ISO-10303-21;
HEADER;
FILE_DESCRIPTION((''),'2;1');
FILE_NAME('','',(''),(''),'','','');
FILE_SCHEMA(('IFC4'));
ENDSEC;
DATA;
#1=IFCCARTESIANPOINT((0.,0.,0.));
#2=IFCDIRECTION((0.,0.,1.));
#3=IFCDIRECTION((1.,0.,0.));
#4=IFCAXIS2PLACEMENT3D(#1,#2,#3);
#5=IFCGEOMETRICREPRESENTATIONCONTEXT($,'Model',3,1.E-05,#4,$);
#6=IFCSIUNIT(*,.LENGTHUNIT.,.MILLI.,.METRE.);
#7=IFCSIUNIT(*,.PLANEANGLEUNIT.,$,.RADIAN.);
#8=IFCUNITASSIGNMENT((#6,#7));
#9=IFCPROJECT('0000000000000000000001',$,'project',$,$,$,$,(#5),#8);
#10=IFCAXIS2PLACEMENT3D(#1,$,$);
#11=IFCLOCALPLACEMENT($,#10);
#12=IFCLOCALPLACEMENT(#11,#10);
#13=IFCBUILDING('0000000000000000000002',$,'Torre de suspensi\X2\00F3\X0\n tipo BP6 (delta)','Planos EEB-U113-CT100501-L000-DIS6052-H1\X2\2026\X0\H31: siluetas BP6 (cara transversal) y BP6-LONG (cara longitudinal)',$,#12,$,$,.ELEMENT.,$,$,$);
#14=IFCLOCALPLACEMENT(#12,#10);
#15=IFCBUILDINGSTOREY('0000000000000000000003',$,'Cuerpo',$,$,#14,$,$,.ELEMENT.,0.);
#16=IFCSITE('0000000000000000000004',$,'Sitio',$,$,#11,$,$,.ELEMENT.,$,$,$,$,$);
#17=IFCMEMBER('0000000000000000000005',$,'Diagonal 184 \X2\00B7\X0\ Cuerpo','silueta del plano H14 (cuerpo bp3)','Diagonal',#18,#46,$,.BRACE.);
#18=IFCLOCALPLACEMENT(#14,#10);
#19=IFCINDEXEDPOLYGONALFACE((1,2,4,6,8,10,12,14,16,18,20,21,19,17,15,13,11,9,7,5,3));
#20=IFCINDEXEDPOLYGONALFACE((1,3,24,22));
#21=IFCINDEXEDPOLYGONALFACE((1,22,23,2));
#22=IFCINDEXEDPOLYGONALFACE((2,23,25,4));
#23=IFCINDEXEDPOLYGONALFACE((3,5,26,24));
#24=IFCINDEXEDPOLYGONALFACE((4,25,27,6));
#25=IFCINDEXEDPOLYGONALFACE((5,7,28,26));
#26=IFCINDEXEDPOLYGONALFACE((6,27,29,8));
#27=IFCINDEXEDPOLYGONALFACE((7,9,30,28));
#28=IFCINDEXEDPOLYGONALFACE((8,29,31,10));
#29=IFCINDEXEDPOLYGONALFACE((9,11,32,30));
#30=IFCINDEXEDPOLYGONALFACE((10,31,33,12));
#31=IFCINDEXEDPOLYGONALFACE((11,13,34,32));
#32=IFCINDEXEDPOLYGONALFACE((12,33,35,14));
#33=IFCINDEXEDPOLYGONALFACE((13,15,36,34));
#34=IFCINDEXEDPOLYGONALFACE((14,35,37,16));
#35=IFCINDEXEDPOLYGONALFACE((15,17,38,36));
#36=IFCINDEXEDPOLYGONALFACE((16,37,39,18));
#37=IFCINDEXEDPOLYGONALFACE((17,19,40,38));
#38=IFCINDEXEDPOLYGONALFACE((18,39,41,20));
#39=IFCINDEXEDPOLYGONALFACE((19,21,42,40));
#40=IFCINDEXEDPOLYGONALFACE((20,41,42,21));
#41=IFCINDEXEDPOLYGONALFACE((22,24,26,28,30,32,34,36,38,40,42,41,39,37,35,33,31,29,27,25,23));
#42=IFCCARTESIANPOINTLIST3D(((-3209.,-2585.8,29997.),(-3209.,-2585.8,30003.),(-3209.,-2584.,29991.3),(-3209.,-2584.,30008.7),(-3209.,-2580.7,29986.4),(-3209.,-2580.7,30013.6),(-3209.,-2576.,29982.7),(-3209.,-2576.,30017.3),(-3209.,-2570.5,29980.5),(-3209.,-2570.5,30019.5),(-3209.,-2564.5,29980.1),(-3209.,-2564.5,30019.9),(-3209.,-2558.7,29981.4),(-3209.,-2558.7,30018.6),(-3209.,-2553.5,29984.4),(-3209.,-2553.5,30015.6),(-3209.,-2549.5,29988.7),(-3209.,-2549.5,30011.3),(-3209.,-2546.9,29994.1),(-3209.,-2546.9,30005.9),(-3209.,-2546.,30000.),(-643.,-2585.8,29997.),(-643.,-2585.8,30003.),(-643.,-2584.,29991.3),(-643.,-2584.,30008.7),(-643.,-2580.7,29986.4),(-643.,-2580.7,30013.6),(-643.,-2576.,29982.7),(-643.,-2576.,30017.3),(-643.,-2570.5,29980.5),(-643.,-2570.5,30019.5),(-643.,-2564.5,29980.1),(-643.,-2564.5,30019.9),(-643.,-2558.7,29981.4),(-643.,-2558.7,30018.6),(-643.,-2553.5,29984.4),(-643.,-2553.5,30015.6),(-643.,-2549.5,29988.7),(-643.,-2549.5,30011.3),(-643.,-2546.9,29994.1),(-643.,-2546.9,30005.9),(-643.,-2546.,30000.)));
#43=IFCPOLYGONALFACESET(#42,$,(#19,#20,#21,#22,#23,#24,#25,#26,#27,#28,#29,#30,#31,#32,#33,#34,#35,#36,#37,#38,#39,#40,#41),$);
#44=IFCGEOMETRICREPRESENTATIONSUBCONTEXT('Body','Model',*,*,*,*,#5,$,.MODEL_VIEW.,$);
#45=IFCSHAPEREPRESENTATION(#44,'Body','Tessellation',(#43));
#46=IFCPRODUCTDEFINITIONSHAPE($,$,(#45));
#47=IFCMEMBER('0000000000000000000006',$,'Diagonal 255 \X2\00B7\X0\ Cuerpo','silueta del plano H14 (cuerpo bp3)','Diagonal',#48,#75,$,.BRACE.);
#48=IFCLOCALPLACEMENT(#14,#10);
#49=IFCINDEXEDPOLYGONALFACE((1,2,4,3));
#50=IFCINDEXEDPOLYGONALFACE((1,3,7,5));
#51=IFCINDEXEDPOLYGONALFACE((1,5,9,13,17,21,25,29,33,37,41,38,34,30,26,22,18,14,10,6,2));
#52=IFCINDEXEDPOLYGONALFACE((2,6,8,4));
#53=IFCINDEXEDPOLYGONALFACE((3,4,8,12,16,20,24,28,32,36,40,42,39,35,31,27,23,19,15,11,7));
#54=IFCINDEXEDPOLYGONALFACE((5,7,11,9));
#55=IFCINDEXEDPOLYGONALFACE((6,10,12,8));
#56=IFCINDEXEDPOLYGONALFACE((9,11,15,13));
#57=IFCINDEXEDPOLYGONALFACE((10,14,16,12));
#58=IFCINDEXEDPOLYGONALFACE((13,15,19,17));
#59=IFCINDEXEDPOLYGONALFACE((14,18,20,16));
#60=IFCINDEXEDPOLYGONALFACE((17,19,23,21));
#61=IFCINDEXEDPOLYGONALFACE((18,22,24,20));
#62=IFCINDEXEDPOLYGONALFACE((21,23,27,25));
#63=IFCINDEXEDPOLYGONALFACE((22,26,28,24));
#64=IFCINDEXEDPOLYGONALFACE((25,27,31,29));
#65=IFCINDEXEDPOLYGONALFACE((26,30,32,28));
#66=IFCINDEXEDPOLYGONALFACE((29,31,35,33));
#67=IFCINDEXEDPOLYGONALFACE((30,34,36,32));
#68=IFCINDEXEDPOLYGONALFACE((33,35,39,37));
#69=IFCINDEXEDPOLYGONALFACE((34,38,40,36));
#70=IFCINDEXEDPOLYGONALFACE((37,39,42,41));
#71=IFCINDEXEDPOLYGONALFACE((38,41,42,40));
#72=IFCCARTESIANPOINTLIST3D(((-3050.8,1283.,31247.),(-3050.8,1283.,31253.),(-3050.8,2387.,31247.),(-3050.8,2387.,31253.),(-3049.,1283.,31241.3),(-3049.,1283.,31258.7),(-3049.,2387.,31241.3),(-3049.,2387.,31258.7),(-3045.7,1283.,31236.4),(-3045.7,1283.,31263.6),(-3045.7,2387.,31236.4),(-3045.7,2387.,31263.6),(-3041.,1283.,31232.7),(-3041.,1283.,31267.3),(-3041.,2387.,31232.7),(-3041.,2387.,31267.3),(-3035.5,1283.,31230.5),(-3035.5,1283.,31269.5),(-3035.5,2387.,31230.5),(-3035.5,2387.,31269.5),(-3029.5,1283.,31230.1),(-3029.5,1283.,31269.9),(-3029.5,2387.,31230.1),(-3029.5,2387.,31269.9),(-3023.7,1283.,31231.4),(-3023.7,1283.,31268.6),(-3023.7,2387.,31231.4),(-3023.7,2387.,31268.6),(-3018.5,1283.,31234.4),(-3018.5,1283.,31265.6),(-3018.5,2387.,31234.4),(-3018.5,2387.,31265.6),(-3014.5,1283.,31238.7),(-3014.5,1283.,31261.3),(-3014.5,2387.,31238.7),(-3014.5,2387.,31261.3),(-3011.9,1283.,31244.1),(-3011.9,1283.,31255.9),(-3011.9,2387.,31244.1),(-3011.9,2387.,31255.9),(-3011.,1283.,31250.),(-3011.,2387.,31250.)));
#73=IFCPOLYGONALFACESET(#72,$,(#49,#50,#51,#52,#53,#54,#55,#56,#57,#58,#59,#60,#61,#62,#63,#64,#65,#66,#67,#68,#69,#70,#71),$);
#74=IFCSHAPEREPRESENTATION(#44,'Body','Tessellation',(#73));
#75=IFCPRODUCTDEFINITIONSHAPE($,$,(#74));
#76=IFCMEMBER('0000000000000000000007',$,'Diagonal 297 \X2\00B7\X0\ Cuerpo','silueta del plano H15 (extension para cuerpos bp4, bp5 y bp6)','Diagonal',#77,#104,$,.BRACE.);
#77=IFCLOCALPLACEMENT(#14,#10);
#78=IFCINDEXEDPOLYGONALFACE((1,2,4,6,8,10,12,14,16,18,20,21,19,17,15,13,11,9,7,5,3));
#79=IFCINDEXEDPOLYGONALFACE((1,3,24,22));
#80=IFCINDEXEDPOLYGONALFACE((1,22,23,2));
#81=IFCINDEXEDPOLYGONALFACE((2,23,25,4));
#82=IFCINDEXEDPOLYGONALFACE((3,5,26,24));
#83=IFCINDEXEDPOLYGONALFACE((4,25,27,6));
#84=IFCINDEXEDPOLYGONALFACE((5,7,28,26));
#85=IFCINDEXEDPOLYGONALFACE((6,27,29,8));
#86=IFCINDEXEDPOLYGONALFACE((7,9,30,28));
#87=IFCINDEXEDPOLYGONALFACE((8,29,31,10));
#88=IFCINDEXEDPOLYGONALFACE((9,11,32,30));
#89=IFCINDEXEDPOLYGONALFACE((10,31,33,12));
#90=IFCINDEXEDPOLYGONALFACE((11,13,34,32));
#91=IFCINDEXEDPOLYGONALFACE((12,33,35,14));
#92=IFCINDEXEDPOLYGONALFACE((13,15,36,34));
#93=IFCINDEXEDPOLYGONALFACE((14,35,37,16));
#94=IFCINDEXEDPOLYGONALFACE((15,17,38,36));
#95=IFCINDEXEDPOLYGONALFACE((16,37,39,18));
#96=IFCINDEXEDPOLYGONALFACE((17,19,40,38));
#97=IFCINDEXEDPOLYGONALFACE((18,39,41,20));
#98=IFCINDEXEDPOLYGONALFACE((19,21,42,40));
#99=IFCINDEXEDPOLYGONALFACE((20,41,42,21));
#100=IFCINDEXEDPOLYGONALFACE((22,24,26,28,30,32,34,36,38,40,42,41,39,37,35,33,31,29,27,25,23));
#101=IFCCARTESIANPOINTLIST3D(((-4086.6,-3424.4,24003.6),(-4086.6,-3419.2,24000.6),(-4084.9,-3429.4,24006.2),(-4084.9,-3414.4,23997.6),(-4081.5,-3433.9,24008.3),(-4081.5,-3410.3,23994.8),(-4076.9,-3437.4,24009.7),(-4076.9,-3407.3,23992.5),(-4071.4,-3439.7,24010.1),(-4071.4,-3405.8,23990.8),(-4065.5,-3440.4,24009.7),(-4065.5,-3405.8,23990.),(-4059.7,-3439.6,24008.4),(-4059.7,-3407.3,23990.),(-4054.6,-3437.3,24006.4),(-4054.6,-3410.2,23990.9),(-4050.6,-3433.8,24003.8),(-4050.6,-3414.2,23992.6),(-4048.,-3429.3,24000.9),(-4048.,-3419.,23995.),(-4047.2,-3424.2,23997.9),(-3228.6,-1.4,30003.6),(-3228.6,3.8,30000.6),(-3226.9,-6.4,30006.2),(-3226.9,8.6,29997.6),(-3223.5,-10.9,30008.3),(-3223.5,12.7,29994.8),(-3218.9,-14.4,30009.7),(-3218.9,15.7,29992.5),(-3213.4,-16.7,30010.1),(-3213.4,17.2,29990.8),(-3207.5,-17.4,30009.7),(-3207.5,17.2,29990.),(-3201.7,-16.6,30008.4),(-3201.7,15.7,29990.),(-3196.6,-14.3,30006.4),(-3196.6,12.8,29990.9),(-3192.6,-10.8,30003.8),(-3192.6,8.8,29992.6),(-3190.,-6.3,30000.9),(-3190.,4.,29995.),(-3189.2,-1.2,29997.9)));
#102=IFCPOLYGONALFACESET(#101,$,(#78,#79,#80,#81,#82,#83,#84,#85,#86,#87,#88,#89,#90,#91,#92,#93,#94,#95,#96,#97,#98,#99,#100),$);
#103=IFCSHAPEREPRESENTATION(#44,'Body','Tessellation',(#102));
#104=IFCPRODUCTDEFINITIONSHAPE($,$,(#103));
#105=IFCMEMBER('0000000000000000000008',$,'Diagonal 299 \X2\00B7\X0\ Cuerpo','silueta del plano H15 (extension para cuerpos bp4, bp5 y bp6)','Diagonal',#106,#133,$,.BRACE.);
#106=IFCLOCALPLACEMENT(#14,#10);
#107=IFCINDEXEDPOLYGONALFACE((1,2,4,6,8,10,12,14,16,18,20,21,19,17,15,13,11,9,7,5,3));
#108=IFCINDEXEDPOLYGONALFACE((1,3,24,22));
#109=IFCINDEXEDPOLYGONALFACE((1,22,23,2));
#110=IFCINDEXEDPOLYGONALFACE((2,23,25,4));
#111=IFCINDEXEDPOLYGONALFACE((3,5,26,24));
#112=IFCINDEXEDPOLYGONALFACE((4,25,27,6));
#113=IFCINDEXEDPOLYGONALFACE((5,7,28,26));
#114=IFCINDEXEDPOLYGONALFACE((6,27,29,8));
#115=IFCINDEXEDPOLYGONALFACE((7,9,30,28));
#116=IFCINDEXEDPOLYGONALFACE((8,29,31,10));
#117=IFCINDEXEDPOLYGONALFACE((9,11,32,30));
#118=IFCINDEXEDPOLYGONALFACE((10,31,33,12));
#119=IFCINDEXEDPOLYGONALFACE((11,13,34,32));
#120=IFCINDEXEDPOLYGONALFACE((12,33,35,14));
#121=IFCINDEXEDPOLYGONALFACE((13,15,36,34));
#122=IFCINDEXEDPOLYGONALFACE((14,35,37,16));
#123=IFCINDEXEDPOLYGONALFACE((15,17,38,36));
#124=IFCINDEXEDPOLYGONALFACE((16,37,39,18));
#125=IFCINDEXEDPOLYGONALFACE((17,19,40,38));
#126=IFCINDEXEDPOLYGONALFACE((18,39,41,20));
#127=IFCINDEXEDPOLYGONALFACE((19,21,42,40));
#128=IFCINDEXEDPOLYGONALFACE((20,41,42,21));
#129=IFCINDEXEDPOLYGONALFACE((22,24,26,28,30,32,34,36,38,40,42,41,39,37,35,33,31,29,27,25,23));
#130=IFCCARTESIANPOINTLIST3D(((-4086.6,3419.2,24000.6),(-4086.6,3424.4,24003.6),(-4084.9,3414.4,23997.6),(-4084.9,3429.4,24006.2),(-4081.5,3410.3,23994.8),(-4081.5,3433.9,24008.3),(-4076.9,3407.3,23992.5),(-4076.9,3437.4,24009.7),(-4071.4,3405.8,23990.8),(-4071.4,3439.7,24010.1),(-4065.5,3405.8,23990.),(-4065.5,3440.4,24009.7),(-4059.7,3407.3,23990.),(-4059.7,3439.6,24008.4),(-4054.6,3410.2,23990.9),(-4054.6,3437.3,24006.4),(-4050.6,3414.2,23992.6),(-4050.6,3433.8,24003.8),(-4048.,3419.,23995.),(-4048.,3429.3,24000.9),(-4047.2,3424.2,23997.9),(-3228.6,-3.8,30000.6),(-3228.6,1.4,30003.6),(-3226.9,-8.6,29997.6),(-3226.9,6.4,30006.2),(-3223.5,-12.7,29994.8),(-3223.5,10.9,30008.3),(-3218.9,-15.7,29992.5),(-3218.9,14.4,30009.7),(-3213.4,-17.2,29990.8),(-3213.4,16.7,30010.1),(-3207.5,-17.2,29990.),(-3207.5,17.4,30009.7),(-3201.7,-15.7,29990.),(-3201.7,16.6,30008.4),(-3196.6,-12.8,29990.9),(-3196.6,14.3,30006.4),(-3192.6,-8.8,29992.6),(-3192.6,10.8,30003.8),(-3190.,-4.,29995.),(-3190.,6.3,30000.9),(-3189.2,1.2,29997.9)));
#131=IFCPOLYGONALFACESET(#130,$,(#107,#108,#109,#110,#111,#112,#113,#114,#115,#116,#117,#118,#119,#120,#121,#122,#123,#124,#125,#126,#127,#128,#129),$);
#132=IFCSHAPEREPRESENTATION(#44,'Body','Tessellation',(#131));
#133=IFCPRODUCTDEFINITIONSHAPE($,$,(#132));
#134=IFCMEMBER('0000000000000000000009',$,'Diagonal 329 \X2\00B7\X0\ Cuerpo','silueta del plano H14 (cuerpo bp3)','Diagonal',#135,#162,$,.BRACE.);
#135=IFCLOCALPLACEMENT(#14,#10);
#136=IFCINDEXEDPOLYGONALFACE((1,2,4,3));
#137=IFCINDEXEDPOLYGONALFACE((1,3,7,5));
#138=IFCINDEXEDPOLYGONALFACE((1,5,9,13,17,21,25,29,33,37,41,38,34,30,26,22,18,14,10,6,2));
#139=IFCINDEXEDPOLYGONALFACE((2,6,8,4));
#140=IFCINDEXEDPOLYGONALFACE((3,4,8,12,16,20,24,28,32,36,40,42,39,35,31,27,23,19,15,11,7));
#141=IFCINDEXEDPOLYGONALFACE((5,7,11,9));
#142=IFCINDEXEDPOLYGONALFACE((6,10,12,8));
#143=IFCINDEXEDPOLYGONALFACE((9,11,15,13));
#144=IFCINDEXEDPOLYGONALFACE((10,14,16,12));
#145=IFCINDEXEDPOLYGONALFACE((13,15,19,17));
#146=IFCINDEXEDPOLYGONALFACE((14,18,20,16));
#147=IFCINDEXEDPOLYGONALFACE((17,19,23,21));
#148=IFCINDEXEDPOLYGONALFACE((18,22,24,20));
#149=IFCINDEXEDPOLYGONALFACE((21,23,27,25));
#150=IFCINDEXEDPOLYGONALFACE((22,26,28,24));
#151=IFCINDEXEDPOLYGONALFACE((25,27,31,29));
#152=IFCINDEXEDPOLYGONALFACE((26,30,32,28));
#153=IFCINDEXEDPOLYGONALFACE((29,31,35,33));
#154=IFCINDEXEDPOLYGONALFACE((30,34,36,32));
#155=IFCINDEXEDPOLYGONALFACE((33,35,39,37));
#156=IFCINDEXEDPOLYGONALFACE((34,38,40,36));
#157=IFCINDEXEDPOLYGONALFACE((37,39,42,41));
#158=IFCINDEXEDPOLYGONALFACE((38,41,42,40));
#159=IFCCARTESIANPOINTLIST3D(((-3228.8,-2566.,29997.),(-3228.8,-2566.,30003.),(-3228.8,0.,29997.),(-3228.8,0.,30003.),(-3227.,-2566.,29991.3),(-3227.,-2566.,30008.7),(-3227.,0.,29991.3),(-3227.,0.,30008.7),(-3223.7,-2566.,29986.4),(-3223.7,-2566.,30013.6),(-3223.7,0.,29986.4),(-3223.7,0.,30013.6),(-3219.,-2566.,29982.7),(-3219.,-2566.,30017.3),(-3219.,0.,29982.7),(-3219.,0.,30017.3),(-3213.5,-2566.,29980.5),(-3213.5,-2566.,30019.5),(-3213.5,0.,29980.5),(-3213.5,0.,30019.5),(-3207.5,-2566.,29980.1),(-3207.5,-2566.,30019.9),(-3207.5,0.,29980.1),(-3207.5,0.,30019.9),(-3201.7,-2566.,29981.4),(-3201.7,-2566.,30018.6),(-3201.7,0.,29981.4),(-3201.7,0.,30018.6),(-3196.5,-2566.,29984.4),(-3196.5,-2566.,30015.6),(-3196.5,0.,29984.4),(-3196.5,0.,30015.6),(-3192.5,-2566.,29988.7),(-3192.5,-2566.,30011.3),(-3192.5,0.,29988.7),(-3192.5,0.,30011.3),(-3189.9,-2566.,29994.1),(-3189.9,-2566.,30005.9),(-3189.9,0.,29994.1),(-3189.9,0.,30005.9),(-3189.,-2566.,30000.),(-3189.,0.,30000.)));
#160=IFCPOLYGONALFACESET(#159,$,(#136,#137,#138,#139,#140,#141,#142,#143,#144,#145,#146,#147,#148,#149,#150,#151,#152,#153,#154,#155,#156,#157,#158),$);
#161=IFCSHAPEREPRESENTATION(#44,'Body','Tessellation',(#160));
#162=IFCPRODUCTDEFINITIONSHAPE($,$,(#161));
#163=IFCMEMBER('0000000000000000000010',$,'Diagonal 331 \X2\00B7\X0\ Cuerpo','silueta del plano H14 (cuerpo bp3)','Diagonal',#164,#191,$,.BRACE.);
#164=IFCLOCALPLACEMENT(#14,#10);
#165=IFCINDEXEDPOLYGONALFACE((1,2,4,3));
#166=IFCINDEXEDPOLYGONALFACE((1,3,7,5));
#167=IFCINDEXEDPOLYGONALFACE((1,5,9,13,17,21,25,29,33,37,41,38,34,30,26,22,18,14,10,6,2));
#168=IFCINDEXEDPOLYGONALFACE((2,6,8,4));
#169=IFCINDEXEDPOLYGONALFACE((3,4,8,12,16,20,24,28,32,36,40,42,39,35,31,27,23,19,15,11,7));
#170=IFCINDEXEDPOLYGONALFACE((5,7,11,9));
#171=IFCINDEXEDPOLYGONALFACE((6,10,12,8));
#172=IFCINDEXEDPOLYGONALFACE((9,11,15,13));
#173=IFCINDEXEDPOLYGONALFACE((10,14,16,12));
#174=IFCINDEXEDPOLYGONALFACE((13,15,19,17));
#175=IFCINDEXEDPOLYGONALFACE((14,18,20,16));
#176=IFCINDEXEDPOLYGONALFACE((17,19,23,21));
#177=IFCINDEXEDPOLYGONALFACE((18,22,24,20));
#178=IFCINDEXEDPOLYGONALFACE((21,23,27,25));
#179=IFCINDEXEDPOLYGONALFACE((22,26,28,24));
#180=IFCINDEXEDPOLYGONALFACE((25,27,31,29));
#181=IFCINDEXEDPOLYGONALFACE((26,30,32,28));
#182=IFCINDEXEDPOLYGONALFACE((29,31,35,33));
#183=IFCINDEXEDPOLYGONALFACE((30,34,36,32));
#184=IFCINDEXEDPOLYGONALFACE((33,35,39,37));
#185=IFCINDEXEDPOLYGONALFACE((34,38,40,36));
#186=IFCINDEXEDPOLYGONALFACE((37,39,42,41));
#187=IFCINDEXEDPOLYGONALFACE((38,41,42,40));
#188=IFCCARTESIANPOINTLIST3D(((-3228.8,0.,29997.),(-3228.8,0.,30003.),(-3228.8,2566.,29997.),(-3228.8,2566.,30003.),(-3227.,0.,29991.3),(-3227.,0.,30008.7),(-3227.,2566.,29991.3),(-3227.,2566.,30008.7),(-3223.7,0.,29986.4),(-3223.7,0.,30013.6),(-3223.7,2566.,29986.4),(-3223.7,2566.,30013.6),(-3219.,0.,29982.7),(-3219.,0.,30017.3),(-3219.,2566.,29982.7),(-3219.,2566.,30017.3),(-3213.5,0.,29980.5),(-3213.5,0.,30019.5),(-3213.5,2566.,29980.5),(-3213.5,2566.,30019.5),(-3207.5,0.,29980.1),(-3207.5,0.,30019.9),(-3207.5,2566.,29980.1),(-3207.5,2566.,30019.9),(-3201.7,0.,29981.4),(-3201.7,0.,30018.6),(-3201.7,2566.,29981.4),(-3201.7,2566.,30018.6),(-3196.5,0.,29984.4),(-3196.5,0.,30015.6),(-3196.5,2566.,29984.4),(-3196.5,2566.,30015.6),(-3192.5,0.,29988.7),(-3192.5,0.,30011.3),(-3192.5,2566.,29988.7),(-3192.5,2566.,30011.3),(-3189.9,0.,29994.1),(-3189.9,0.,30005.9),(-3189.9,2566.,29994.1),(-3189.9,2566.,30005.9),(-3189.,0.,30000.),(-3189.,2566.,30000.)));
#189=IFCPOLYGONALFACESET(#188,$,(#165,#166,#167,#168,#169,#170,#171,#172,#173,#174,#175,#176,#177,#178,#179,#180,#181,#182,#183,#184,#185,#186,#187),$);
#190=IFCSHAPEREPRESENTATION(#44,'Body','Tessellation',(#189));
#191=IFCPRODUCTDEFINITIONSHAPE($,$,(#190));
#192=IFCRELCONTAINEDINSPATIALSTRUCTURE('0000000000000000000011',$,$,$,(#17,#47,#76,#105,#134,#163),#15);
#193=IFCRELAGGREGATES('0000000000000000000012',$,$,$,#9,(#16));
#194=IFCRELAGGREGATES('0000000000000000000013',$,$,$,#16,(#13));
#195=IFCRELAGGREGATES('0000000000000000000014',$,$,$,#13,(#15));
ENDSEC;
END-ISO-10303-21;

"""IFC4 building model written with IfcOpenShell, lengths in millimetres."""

from ifc_helpers import new_model, si_unit, frame, origin, origin_with_axes, place, context, subcontext, project, spatial, circle, extrude, element, save


model = new_model("IFC4")

# Units and contexts
model_context = context("Model", 3, precision=1e-05, world=origin_with_axes())
body_context = subcontext(model_context, "Body", "Model", "MODEL_VIEW")
ifc_project = project(units=[si_unit("LENGTHUNIT", "METRE", prefix="MILLI"), si_unit("PLANEANGLEUNIT", "RADIAN")], contexts=[model_context])

# Site, building, storey
site_placement = place(None, origin())
site = spatial("IfcSite", under=ifc_project, at=site_placement, Name="Sitio", CompositionType="ELEMENT")
building_placement = place(site_placement, origin())
building = spatial("IfcBuilding", under=site, at=building_placement, Name="Torre de suspensión tipo BP6 (delta)", Description="Planos EEB-U113-CT100501-L000-DIS6052-H1…H31: siluetas BP6 (cara transversal) y BP6-LONG (cara longitudinal)", CompositionType="ELEMENT")
storey_placement = place(building_placement, origin())
storey = spatial("IfcBuildingStorey", under=building, at=storey_placement, Name="Cuerpo", CompositionType="ELEMENT", Elevation=0.0)

# Members
for number, where, z_axis, x_axis, name in (
    (1, (-3209.0, -2566.0, 30000.0), (1.0, 0.0, 0.0), (0.0, 1.0, 0.0), "Diagonal 184 · Cuerpo"),
):
    element("IfcMember", number, at=place(storey_placement, frame(where, z_axis=z_axis, x_axis=x_axis)), inside=storey, Name=name, Description="silueta del plano H14 (cuerpo bp3)", ObjectType="Diagonal", PredefinedType="BRACE", context=body_context, shape_type="SweptSolid", body=[
        extrude(circle(Radius=20.0), None, (0.0, 0.0, 1.0), 2566.0),
    ])
member_1_placement = place(storey_placement, frame((-3031.0, 1283.0, 31250.0), z_axis=(0.0, 1.0, 0.0), x_axis=(1.0, 0.0, 0.0)))
element("IfcMember", 2, at=member_1_placement, inside=storey, Name="Diagonal 255 · Cuerpo", Description="silueta del plano H14 (cuerpo bp3)", ObjectType="Diagonal", PredefinedType="BRACE", context=body_context, shape_type="SweptSolid", body=[
    extrude(circle(Radius=20.0), None, (0.0, 0.0, 1.0), 1104.0),
])
for number, where, z_axis, x_axis, name in (
    (3, (-3209.0, 0.0, 30000.0), (-0.123261, -0.491752, -0.861967), (0.992374, -0.06108, -0.107064), "Diagonal 297 · Cuerpo"),
    (4, (-3209.0, 0.0, 30000.0), (-0.123261, 0.491752, -0.861967), (0.992374, 0.06108, -0.107064), "Diagonal 299 · Cuerpo"),
):
    element("IfcMember", number, at=place(storey_placement, frame(where, z_axis=z_axis, x_axis=x_axis)), inside=storey, Name=name, Description="silueta del plano H15 (extension para cuerpos bp4, bp5 y bp6)", ObjectType="Diagonal", PredefinedType="BRACE", context=body_context, shape_type="SweptSolid", body=[
        extrude(circle(Radius=20.0), None, (0.0, 0.0, 1.0), 6960.8),
    ])
for number, where, z_axis, x_axis, name in (
    (5, (-3209.0, -2566.0, 30000.0), (0.0, 1.0, 0.0), (1.0, 0.0, 0.0), "Diagonal 329 · Cuerpo"),
    (6, (-3209.0, 2566.0, 30000.0), (0.0, -1.0, 0.0), (1.0, 0.0, 0.0), "Diagonal 331 · Cuerpo"),
):
    element("IfcMember", number, at=place(storey_placement, frame(where, z_axis=z_axis, x_axis=x_axis)), inside=storey, Name=name, Description="silueta del plano H14 (cuerpo bp3)", ObjectType="Diagonal", PredefinedType="BRACE", context=body_context, shape_type="SweptSolid", body=[
        extrude(circle(Radius=20.0), None, (0.0, 0.0, 1.0), 2566.0),
    ])

save(model, "model.ifc")
